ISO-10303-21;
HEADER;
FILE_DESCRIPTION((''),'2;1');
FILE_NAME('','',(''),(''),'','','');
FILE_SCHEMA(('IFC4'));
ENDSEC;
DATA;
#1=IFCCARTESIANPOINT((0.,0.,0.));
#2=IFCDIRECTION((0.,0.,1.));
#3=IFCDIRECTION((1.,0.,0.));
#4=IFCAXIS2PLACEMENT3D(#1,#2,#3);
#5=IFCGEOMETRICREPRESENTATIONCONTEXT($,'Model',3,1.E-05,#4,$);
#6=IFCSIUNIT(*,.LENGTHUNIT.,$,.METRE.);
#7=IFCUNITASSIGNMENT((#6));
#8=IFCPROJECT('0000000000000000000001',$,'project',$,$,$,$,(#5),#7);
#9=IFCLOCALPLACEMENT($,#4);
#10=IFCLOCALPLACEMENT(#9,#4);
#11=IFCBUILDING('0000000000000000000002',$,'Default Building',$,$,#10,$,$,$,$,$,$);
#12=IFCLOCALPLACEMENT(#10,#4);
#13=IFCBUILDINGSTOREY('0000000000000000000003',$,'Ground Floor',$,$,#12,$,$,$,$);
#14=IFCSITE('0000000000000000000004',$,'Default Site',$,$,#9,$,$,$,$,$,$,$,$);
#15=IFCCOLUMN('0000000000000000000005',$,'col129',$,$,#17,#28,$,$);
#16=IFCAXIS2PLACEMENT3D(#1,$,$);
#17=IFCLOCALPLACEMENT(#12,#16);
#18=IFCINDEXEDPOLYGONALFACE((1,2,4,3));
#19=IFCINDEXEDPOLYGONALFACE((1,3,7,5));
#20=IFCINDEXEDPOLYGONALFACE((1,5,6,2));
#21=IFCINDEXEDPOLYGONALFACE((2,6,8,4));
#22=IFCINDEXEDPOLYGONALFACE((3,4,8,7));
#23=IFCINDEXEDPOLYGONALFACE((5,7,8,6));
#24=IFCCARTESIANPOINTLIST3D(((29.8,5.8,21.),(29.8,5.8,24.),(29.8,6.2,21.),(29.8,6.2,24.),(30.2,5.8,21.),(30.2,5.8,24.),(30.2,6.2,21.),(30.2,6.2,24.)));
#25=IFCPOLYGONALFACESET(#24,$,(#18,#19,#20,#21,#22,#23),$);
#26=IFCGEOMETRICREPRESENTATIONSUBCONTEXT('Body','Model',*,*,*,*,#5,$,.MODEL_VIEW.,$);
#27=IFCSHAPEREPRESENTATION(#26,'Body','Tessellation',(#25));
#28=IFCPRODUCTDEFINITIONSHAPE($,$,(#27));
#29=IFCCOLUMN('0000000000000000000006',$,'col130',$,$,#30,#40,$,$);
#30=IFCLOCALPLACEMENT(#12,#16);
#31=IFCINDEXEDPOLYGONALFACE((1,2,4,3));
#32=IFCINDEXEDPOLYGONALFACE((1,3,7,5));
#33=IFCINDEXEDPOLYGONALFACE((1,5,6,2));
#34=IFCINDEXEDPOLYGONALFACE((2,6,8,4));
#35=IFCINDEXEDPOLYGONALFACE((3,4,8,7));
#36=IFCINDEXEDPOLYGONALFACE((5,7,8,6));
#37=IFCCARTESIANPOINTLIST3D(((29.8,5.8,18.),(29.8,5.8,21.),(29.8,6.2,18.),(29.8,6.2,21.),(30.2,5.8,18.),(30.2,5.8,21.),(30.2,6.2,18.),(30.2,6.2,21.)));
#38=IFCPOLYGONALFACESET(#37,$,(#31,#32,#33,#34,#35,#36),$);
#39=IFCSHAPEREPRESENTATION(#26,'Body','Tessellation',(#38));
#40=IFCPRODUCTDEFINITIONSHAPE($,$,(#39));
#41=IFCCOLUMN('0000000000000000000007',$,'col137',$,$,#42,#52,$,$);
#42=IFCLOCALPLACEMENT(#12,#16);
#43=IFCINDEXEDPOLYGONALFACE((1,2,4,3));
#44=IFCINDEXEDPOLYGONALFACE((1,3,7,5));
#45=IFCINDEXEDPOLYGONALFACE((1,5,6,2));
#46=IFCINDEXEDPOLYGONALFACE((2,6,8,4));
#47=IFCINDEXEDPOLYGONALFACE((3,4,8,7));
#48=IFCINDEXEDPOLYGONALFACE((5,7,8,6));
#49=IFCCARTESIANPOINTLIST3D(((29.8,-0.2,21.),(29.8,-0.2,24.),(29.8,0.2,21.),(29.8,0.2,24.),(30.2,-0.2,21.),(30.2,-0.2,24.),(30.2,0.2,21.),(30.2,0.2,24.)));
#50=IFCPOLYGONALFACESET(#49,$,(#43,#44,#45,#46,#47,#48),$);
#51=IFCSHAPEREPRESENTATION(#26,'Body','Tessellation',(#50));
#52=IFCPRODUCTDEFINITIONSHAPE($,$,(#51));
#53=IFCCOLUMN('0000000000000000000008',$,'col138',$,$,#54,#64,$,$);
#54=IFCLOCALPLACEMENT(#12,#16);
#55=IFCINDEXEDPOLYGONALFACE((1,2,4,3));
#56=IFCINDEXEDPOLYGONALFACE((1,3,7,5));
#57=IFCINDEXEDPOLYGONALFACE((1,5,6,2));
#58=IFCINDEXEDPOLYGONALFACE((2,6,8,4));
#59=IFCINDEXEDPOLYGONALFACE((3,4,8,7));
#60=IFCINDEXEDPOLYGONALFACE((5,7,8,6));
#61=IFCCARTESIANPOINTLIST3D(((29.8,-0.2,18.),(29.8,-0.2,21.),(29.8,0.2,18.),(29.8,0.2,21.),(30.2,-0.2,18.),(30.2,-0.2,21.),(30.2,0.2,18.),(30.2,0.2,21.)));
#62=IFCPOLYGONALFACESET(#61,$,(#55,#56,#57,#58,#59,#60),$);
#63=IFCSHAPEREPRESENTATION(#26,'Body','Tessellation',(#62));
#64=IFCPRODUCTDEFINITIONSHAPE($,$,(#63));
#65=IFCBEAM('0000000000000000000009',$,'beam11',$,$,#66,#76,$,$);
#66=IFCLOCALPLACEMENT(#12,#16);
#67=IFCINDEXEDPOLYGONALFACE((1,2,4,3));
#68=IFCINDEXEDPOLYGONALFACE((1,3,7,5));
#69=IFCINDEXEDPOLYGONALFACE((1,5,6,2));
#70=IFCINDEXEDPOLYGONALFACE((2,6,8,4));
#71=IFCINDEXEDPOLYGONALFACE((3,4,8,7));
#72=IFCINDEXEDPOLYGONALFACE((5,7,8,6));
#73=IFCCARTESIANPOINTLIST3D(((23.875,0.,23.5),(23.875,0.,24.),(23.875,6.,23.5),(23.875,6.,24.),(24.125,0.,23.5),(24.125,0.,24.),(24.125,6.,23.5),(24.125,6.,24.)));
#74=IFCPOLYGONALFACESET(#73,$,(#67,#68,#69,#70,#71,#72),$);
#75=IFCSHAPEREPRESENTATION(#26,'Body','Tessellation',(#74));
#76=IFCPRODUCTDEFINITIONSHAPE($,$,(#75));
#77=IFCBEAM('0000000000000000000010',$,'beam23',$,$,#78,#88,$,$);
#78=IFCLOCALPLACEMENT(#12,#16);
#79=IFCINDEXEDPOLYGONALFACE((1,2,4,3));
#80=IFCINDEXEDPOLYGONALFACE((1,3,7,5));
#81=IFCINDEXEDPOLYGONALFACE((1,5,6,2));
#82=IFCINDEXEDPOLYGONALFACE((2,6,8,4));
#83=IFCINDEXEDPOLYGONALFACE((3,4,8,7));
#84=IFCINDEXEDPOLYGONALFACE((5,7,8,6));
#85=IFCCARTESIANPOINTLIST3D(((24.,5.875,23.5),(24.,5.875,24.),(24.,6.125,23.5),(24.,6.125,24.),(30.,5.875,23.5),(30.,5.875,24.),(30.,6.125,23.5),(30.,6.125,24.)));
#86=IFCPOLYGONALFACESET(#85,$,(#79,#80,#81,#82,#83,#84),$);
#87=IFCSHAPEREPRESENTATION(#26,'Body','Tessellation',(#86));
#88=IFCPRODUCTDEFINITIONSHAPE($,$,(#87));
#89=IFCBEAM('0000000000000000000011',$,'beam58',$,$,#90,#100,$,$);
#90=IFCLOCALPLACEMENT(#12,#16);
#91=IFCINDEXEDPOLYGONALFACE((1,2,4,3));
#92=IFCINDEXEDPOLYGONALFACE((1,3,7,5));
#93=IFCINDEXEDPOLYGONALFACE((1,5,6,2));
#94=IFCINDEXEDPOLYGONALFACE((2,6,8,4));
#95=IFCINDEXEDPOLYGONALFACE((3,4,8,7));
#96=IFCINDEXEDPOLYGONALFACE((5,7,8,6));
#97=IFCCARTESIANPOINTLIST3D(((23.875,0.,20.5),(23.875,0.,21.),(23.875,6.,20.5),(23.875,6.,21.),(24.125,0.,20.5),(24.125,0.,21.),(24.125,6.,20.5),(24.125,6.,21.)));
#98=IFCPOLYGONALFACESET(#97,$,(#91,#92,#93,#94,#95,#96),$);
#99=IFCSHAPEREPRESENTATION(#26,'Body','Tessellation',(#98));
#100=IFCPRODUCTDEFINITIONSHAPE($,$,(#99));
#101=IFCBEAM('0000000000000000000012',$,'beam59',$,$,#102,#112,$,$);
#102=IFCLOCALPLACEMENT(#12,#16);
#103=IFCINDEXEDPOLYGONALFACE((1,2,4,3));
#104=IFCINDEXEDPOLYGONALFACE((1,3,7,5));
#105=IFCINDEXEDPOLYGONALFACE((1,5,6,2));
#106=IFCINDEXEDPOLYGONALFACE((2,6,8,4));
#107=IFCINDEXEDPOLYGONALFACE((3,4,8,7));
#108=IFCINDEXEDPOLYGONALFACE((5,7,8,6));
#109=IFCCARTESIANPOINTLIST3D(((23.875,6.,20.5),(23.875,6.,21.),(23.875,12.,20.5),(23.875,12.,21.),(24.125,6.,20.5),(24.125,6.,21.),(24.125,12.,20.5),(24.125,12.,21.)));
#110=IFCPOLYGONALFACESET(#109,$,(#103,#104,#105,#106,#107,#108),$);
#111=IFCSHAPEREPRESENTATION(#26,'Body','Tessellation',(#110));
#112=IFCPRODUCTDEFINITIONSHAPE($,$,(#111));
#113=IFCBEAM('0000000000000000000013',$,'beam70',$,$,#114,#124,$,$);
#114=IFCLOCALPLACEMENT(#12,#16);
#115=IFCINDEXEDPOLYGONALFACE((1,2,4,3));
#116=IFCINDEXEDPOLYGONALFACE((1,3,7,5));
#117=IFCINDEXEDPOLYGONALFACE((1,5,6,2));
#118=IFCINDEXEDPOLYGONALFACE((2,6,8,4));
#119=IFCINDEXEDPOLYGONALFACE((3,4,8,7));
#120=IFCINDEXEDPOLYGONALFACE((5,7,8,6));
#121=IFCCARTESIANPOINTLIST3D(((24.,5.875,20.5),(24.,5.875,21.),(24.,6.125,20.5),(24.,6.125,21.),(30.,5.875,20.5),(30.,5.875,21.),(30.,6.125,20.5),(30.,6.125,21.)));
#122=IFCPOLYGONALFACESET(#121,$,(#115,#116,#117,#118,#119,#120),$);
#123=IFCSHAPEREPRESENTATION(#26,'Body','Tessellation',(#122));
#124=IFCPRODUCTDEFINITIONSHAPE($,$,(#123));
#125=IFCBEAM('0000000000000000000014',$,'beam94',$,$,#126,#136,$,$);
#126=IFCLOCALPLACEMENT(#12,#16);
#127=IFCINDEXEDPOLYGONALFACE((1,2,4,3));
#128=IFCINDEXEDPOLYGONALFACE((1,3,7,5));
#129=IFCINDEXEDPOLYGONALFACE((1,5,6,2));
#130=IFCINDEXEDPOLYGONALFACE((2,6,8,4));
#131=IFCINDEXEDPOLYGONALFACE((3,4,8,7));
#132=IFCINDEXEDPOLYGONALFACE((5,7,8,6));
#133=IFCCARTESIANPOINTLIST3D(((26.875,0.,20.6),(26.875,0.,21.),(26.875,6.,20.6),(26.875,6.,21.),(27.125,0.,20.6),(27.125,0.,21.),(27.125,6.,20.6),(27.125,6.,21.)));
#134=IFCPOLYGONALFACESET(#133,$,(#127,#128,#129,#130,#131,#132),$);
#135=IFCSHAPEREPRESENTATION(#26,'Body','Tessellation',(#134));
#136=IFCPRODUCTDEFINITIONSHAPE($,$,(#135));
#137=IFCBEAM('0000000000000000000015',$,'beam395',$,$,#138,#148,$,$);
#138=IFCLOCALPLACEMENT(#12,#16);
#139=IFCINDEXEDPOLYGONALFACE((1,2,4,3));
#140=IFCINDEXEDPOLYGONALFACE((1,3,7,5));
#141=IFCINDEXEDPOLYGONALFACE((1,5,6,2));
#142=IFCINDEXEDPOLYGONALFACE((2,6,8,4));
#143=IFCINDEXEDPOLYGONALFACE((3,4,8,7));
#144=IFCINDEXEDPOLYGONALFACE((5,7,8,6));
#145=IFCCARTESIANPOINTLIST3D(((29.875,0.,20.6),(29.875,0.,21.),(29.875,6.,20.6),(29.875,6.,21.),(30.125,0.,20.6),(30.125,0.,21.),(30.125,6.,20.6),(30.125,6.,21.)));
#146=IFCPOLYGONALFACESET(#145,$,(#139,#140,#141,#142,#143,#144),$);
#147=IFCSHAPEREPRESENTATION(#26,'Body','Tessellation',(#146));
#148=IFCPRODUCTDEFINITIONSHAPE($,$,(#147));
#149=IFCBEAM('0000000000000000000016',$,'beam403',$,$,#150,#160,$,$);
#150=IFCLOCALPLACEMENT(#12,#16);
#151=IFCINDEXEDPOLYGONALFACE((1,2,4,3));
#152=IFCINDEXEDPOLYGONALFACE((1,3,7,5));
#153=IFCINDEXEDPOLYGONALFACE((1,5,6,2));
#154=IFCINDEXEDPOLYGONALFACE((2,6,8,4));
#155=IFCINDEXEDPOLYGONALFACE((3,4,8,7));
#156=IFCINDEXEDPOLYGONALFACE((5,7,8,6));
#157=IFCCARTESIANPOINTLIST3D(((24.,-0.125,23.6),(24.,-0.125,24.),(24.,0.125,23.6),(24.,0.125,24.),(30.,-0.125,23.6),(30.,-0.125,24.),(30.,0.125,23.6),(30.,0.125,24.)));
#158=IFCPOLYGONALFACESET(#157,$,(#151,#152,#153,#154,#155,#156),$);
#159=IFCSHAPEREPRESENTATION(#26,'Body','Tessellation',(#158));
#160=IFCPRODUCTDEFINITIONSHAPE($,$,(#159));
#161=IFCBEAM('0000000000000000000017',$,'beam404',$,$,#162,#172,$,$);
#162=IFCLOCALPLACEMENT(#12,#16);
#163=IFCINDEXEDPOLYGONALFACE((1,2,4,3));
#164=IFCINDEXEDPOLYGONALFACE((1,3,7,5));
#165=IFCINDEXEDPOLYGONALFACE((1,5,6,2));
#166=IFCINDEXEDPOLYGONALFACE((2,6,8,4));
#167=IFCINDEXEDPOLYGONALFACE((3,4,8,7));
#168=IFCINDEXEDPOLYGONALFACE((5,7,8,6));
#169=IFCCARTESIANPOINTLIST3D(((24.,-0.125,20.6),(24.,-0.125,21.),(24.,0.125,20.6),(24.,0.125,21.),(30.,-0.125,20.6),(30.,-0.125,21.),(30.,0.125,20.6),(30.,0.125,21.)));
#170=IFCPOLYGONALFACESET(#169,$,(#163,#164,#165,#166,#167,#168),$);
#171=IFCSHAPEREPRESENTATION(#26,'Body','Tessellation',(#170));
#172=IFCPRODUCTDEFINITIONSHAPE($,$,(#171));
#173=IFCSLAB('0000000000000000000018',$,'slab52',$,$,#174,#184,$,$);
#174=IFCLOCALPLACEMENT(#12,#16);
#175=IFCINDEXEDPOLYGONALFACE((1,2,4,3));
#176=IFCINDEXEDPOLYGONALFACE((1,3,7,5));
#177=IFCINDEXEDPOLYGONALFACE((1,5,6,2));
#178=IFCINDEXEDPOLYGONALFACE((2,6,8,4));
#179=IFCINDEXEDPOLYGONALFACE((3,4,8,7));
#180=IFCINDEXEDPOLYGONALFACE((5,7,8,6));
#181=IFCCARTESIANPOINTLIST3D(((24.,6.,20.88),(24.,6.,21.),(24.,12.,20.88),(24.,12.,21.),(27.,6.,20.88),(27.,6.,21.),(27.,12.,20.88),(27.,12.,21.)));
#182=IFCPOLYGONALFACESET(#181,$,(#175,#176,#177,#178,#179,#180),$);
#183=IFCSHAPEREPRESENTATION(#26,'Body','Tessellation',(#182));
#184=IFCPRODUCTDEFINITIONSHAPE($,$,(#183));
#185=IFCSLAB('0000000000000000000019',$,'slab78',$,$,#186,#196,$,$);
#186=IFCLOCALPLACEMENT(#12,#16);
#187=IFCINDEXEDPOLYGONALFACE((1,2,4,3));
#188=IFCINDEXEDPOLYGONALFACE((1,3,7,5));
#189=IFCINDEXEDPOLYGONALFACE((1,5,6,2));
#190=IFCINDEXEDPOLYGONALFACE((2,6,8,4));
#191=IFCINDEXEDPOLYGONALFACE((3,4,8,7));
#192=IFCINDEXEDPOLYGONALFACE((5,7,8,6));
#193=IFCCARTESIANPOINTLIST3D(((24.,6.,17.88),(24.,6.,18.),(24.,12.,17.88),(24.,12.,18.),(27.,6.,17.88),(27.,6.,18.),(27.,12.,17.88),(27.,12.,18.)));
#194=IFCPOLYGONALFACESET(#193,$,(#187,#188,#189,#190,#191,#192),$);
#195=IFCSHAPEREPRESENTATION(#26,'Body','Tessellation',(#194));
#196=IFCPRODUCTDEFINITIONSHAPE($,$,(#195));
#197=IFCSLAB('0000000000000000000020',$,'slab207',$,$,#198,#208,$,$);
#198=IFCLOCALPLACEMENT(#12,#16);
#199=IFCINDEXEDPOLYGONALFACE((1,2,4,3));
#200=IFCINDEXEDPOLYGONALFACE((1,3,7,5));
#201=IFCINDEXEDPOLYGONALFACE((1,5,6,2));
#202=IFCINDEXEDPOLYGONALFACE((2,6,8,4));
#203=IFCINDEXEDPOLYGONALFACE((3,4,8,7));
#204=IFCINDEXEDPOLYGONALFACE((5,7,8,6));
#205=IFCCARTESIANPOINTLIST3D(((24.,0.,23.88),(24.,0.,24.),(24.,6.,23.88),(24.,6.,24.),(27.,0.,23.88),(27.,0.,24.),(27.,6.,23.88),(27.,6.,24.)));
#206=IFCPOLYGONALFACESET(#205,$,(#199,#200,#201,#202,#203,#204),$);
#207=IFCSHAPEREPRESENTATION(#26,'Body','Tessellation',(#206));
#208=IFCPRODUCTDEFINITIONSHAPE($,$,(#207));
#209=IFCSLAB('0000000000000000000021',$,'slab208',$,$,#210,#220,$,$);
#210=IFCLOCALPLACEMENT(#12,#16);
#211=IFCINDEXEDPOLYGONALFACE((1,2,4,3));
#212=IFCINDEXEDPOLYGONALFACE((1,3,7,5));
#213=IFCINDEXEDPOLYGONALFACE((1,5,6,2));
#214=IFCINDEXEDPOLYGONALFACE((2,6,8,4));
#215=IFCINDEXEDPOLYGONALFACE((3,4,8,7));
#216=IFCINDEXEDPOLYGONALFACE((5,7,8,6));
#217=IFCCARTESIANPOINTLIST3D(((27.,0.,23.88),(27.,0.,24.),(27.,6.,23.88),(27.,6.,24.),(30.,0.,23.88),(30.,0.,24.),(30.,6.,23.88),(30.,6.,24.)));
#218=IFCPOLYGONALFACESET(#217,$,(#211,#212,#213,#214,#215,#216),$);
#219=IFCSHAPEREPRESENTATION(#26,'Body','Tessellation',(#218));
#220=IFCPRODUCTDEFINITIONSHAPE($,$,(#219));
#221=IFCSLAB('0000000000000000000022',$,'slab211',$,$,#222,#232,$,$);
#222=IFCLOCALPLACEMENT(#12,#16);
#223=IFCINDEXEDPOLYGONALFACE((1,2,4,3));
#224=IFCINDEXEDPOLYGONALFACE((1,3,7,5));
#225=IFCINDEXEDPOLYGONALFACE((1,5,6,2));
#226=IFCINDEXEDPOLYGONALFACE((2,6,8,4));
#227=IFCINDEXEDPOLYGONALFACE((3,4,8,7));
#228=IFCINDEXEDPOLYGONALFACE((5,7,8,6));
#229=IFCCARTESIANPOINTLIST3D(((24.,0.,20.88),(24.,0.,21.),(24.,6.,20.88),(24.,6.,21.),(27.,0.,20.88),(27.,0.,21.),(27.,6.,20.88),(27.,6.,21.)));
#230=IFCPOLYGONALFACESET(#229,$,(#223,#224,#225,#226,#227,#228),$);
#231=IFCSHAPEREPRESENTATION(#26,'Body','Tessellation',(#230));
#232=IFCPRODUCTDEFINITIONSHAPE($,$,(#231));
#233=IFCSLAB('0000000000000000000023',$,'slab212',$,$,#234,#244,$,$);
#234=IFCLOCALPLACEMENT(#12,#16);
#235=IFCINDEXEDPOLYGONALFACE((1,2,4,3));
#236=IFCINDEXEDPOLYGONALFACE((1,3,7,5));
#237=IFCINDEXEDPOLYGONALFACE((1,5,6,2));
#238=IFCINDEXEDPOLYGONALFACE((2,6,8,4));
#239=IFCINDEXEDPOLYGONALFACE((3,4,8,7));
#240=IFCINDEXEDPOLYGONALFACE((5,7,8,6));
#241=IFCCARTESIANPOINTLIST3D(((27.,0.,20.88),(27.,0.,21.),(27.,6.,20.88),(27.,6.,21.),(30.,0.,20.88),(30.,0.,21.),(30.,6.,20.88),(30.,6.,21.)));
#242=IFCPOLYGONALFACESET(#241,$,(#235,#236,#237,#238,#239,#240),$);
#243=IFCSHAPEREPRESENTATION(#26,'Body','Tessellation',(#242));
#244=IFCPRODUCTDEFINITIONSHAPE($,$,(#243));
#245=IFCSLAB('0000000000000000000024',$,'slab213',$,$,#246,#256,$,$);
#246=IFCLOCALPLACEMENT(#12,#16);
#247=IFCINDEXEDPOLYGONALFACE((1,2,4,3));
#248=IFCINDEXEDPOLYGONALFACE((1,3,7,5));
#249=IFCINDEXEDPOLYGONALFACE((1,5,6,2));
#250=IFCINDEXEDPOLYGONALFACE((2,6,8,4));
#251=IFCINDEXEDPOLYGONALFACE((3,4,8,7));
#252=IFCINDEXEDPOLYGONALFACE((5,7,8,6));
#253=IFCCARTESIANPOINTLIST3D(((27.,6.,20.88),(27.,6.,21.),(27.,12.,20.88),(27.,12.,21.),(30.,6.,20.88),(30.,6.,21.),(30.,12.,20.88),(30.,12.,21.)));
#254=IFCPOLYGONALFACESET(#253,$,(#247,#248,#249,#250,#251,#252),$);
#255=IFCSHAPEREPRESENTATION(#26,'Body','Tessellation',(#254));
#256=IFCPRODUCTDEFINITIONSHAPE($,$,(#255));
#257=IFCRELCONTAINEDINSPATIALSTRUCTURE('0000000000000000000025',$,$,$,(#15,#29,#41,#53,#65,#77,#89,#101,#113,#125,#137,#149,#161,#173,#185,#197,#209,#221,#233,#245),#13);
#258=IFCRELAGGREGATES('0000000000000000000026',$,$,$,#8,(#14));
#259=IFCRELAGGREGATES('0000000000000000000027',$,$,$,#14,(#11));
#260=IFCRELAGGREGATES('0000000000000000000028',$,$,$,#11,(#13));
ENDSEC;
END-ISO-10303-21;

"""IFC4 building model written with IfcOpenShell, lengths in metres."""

from ifc_helpers import new_model, si_unit, frame, origin_with_axes, place, context, subcontext, project, spatial, indexed_curve, outline, extrude, element, save


model = new_model("IFC4")

# Units and contexts
model_context = context("Model", 3, precision=1e-05, world=origin_with_axes())
body_context = subcontext(model_context, "Body", "Model", "MODEL_VIEW")
ifc_project = project(units=[si_unit("LENGTHUNIT", "METRE")], contexts=[model_context])

# Site, building, storey
site_placement = place(None, origin_with_axes())
site = spatial("IfcSite", under=ifc_project, at=site_placement, Name="Default Site")
building_placement = place(site_placement, origin_with_axes())
building = spatial("IfcBuilding", under=site, at=building_placement, Name="Default Building")
storey_placement = place(building_placement, origin_with_axes())
storey = spatial("IfcBuildingStorey", under=building, at=storey_placement, Name="Ground Floor")

# Columns
for number, where, z_axis, x_axis, name in (
    (1, (29.8, 5.8, 21.0), (0.0, 0.0, 1.0), (1.0, 0.0, 0.0), "col129"),
    (2, (29.8, 5.8, 18.0), (0.0, 0.0, 1.0), (1.0, 0.0, 0.0), "col130"),
    (3, (29.8, -0.2, 21.0), (0.0, 0.0, 1.0), (1.0, 0.0, 0.0), "col137"),
    (4, (29.8, -0.2, 18.0), (0.0, 0.0, 1.0), (1.0, 0.0, 0.0), "col138"),
):
    element("IfcColumn", number, at=place(storey_placement, frame(where, z_axis=z_axis, x_axis=x_axis)), inside=storey, Name=name, context=body_context, shape_type="SweptSolid", body=[
        extrude(outline(indexed_curve([(0.0, 0.0), (0.0, 0.4), (0.4, 0.4), (0.4, 0.0), (0.0, 0.0)], self_intersect=False)), origin_with_axes(), (0.0, 0.0, 1.0), 3.0),
    ])

# Beams
for number, where, z_axis, x_axis, name in (
    (5, (24.125, 0.0, 23.5), (0.0, 0.0, 1.0), (0.0, 1.0, 0.0), "beam11"),
    (6, (24.0, 5.875, 23.5), (0.0, 0.0, 1.0), (1.0, 0.0, 0.0), "beam23"),
    (7, (24.125, 0.0, 20.5), (0.0, 0.0, 1.0), (0.0, 1.0, 0.0), "beam58"),
    (8, (24.125, 6.0, 20.5), (0.0, 0.0, 1.0), (0.0, 1.0, 0.0), "beam59"),
    (9, (24.0, 5.875, 20.5), (0.0, 0.0, 1.0), (1.0, 0.0, 0.0), "beam70"),
):
    element("IfcBeam", number, at=place(storey_placement, frame(where, z_axis=z_axis, x_axis=x_axis)), inside=storey, Name=name, context=body_context, shape_type="SweptSolid", body=[
        extrude(outline(indexed_curve([(0.0, 0.0), (0.0, 0.25), (6.0, 0.25), (6.0, 0.0), (0.0, 0.0)], self_intersect=False)), origin_with_axes(), (0.0, 0.0, 1.0), 0.5),
    ])
for number, where, z_axis, x_axis, name in (
    (10, (26.875, 6.0, 20.6), (0.0, 0.0, 1.0), (0.0, -1.0, 0.0), "beam94"),
    (11, (29.875, 6.0, 20.6), (0.0, 0.0, 1.0), (0.0, -1.0, 0.0), "beam395"),
    (12, (24.0, -0.125, 23.6), (0.0, 0.0, 1.0), (1.0, 0.0, 0.0), "beam403"),
    (13, (24.0, -0.125, 20.6), (0.0, 0.0, 1.0), (1.0, 0.0, 0.0), "beam404"),
):
    element("IfcBeam", number, at=place(storey_placement, frame(where, z_axis=z_axis, x_axis=x_axis)), inside=storey, Name=name, context=body_context, shape_type="SweptSolid", body=[
        extrude(outline(indexed_curve([(0.0, 0.0), (0.0, 0.25), (6.0, 0.25), (6.0, 0.0), (0.0, 0.0)], self_intersect=False)), origin_with_axes(), (0.0, 0.0, 1.0), 0.4),
    ])

# Slabs
for number, where, z_axis, x_axis, name in (
    (14, (24.0, 6.0, 20.88), (0.0, 0.0, 1.0), (1.0, 0.0, 0.0), "slab52"),
    (15, (24.0, 6.0, 17.88), (0.0, 0.0, 1.0), (1.0, 0.0, 0.0), "slab78"),
    (16, (24.0, 0.0, 23.88), (0.0, 0.0, 1.0), (1.0, 0.0, 0.0), "slab207"),
    (17, (27.0, 0.0, 23.88), (0.0, 0.0, 1.0), (1.0, 0.0, 0.0), "slab208"),
    (18, (24.0, 0.0, 20.88), (0.0, 0.0, 1.0), (1.0, 0.0, 0.0), "slab211"),
    (19, (27.0, 0.0, 20.88), (0.0, 0.0, 1.0), (1.0, 0.0, 0.0), "slab212"),
    (20, (27.0, 6.0, 20.88), (0.0, 0.0, 1.0), (1.0, 0.0, 0.0), "slab213"),
):
    element("IfcSlab", number, at=place(storey_placement, frame(where, z_axis=z_axis, x_axis=x_axis)), inside=storey, Name=name, context=body_context, shape_type="SweptSolid", body=[
        extrude(outline(indexed_curve([(0.0, 0.0), (0.0, 6.0), (3.0, 6.0), (3.0, 0.0), (0.0, 0.0)], self_intersect=False)), origin_with_axes(), (0.0, 0.0, 1.0), 0.12),
    ])

save(model, "model.ifc")
